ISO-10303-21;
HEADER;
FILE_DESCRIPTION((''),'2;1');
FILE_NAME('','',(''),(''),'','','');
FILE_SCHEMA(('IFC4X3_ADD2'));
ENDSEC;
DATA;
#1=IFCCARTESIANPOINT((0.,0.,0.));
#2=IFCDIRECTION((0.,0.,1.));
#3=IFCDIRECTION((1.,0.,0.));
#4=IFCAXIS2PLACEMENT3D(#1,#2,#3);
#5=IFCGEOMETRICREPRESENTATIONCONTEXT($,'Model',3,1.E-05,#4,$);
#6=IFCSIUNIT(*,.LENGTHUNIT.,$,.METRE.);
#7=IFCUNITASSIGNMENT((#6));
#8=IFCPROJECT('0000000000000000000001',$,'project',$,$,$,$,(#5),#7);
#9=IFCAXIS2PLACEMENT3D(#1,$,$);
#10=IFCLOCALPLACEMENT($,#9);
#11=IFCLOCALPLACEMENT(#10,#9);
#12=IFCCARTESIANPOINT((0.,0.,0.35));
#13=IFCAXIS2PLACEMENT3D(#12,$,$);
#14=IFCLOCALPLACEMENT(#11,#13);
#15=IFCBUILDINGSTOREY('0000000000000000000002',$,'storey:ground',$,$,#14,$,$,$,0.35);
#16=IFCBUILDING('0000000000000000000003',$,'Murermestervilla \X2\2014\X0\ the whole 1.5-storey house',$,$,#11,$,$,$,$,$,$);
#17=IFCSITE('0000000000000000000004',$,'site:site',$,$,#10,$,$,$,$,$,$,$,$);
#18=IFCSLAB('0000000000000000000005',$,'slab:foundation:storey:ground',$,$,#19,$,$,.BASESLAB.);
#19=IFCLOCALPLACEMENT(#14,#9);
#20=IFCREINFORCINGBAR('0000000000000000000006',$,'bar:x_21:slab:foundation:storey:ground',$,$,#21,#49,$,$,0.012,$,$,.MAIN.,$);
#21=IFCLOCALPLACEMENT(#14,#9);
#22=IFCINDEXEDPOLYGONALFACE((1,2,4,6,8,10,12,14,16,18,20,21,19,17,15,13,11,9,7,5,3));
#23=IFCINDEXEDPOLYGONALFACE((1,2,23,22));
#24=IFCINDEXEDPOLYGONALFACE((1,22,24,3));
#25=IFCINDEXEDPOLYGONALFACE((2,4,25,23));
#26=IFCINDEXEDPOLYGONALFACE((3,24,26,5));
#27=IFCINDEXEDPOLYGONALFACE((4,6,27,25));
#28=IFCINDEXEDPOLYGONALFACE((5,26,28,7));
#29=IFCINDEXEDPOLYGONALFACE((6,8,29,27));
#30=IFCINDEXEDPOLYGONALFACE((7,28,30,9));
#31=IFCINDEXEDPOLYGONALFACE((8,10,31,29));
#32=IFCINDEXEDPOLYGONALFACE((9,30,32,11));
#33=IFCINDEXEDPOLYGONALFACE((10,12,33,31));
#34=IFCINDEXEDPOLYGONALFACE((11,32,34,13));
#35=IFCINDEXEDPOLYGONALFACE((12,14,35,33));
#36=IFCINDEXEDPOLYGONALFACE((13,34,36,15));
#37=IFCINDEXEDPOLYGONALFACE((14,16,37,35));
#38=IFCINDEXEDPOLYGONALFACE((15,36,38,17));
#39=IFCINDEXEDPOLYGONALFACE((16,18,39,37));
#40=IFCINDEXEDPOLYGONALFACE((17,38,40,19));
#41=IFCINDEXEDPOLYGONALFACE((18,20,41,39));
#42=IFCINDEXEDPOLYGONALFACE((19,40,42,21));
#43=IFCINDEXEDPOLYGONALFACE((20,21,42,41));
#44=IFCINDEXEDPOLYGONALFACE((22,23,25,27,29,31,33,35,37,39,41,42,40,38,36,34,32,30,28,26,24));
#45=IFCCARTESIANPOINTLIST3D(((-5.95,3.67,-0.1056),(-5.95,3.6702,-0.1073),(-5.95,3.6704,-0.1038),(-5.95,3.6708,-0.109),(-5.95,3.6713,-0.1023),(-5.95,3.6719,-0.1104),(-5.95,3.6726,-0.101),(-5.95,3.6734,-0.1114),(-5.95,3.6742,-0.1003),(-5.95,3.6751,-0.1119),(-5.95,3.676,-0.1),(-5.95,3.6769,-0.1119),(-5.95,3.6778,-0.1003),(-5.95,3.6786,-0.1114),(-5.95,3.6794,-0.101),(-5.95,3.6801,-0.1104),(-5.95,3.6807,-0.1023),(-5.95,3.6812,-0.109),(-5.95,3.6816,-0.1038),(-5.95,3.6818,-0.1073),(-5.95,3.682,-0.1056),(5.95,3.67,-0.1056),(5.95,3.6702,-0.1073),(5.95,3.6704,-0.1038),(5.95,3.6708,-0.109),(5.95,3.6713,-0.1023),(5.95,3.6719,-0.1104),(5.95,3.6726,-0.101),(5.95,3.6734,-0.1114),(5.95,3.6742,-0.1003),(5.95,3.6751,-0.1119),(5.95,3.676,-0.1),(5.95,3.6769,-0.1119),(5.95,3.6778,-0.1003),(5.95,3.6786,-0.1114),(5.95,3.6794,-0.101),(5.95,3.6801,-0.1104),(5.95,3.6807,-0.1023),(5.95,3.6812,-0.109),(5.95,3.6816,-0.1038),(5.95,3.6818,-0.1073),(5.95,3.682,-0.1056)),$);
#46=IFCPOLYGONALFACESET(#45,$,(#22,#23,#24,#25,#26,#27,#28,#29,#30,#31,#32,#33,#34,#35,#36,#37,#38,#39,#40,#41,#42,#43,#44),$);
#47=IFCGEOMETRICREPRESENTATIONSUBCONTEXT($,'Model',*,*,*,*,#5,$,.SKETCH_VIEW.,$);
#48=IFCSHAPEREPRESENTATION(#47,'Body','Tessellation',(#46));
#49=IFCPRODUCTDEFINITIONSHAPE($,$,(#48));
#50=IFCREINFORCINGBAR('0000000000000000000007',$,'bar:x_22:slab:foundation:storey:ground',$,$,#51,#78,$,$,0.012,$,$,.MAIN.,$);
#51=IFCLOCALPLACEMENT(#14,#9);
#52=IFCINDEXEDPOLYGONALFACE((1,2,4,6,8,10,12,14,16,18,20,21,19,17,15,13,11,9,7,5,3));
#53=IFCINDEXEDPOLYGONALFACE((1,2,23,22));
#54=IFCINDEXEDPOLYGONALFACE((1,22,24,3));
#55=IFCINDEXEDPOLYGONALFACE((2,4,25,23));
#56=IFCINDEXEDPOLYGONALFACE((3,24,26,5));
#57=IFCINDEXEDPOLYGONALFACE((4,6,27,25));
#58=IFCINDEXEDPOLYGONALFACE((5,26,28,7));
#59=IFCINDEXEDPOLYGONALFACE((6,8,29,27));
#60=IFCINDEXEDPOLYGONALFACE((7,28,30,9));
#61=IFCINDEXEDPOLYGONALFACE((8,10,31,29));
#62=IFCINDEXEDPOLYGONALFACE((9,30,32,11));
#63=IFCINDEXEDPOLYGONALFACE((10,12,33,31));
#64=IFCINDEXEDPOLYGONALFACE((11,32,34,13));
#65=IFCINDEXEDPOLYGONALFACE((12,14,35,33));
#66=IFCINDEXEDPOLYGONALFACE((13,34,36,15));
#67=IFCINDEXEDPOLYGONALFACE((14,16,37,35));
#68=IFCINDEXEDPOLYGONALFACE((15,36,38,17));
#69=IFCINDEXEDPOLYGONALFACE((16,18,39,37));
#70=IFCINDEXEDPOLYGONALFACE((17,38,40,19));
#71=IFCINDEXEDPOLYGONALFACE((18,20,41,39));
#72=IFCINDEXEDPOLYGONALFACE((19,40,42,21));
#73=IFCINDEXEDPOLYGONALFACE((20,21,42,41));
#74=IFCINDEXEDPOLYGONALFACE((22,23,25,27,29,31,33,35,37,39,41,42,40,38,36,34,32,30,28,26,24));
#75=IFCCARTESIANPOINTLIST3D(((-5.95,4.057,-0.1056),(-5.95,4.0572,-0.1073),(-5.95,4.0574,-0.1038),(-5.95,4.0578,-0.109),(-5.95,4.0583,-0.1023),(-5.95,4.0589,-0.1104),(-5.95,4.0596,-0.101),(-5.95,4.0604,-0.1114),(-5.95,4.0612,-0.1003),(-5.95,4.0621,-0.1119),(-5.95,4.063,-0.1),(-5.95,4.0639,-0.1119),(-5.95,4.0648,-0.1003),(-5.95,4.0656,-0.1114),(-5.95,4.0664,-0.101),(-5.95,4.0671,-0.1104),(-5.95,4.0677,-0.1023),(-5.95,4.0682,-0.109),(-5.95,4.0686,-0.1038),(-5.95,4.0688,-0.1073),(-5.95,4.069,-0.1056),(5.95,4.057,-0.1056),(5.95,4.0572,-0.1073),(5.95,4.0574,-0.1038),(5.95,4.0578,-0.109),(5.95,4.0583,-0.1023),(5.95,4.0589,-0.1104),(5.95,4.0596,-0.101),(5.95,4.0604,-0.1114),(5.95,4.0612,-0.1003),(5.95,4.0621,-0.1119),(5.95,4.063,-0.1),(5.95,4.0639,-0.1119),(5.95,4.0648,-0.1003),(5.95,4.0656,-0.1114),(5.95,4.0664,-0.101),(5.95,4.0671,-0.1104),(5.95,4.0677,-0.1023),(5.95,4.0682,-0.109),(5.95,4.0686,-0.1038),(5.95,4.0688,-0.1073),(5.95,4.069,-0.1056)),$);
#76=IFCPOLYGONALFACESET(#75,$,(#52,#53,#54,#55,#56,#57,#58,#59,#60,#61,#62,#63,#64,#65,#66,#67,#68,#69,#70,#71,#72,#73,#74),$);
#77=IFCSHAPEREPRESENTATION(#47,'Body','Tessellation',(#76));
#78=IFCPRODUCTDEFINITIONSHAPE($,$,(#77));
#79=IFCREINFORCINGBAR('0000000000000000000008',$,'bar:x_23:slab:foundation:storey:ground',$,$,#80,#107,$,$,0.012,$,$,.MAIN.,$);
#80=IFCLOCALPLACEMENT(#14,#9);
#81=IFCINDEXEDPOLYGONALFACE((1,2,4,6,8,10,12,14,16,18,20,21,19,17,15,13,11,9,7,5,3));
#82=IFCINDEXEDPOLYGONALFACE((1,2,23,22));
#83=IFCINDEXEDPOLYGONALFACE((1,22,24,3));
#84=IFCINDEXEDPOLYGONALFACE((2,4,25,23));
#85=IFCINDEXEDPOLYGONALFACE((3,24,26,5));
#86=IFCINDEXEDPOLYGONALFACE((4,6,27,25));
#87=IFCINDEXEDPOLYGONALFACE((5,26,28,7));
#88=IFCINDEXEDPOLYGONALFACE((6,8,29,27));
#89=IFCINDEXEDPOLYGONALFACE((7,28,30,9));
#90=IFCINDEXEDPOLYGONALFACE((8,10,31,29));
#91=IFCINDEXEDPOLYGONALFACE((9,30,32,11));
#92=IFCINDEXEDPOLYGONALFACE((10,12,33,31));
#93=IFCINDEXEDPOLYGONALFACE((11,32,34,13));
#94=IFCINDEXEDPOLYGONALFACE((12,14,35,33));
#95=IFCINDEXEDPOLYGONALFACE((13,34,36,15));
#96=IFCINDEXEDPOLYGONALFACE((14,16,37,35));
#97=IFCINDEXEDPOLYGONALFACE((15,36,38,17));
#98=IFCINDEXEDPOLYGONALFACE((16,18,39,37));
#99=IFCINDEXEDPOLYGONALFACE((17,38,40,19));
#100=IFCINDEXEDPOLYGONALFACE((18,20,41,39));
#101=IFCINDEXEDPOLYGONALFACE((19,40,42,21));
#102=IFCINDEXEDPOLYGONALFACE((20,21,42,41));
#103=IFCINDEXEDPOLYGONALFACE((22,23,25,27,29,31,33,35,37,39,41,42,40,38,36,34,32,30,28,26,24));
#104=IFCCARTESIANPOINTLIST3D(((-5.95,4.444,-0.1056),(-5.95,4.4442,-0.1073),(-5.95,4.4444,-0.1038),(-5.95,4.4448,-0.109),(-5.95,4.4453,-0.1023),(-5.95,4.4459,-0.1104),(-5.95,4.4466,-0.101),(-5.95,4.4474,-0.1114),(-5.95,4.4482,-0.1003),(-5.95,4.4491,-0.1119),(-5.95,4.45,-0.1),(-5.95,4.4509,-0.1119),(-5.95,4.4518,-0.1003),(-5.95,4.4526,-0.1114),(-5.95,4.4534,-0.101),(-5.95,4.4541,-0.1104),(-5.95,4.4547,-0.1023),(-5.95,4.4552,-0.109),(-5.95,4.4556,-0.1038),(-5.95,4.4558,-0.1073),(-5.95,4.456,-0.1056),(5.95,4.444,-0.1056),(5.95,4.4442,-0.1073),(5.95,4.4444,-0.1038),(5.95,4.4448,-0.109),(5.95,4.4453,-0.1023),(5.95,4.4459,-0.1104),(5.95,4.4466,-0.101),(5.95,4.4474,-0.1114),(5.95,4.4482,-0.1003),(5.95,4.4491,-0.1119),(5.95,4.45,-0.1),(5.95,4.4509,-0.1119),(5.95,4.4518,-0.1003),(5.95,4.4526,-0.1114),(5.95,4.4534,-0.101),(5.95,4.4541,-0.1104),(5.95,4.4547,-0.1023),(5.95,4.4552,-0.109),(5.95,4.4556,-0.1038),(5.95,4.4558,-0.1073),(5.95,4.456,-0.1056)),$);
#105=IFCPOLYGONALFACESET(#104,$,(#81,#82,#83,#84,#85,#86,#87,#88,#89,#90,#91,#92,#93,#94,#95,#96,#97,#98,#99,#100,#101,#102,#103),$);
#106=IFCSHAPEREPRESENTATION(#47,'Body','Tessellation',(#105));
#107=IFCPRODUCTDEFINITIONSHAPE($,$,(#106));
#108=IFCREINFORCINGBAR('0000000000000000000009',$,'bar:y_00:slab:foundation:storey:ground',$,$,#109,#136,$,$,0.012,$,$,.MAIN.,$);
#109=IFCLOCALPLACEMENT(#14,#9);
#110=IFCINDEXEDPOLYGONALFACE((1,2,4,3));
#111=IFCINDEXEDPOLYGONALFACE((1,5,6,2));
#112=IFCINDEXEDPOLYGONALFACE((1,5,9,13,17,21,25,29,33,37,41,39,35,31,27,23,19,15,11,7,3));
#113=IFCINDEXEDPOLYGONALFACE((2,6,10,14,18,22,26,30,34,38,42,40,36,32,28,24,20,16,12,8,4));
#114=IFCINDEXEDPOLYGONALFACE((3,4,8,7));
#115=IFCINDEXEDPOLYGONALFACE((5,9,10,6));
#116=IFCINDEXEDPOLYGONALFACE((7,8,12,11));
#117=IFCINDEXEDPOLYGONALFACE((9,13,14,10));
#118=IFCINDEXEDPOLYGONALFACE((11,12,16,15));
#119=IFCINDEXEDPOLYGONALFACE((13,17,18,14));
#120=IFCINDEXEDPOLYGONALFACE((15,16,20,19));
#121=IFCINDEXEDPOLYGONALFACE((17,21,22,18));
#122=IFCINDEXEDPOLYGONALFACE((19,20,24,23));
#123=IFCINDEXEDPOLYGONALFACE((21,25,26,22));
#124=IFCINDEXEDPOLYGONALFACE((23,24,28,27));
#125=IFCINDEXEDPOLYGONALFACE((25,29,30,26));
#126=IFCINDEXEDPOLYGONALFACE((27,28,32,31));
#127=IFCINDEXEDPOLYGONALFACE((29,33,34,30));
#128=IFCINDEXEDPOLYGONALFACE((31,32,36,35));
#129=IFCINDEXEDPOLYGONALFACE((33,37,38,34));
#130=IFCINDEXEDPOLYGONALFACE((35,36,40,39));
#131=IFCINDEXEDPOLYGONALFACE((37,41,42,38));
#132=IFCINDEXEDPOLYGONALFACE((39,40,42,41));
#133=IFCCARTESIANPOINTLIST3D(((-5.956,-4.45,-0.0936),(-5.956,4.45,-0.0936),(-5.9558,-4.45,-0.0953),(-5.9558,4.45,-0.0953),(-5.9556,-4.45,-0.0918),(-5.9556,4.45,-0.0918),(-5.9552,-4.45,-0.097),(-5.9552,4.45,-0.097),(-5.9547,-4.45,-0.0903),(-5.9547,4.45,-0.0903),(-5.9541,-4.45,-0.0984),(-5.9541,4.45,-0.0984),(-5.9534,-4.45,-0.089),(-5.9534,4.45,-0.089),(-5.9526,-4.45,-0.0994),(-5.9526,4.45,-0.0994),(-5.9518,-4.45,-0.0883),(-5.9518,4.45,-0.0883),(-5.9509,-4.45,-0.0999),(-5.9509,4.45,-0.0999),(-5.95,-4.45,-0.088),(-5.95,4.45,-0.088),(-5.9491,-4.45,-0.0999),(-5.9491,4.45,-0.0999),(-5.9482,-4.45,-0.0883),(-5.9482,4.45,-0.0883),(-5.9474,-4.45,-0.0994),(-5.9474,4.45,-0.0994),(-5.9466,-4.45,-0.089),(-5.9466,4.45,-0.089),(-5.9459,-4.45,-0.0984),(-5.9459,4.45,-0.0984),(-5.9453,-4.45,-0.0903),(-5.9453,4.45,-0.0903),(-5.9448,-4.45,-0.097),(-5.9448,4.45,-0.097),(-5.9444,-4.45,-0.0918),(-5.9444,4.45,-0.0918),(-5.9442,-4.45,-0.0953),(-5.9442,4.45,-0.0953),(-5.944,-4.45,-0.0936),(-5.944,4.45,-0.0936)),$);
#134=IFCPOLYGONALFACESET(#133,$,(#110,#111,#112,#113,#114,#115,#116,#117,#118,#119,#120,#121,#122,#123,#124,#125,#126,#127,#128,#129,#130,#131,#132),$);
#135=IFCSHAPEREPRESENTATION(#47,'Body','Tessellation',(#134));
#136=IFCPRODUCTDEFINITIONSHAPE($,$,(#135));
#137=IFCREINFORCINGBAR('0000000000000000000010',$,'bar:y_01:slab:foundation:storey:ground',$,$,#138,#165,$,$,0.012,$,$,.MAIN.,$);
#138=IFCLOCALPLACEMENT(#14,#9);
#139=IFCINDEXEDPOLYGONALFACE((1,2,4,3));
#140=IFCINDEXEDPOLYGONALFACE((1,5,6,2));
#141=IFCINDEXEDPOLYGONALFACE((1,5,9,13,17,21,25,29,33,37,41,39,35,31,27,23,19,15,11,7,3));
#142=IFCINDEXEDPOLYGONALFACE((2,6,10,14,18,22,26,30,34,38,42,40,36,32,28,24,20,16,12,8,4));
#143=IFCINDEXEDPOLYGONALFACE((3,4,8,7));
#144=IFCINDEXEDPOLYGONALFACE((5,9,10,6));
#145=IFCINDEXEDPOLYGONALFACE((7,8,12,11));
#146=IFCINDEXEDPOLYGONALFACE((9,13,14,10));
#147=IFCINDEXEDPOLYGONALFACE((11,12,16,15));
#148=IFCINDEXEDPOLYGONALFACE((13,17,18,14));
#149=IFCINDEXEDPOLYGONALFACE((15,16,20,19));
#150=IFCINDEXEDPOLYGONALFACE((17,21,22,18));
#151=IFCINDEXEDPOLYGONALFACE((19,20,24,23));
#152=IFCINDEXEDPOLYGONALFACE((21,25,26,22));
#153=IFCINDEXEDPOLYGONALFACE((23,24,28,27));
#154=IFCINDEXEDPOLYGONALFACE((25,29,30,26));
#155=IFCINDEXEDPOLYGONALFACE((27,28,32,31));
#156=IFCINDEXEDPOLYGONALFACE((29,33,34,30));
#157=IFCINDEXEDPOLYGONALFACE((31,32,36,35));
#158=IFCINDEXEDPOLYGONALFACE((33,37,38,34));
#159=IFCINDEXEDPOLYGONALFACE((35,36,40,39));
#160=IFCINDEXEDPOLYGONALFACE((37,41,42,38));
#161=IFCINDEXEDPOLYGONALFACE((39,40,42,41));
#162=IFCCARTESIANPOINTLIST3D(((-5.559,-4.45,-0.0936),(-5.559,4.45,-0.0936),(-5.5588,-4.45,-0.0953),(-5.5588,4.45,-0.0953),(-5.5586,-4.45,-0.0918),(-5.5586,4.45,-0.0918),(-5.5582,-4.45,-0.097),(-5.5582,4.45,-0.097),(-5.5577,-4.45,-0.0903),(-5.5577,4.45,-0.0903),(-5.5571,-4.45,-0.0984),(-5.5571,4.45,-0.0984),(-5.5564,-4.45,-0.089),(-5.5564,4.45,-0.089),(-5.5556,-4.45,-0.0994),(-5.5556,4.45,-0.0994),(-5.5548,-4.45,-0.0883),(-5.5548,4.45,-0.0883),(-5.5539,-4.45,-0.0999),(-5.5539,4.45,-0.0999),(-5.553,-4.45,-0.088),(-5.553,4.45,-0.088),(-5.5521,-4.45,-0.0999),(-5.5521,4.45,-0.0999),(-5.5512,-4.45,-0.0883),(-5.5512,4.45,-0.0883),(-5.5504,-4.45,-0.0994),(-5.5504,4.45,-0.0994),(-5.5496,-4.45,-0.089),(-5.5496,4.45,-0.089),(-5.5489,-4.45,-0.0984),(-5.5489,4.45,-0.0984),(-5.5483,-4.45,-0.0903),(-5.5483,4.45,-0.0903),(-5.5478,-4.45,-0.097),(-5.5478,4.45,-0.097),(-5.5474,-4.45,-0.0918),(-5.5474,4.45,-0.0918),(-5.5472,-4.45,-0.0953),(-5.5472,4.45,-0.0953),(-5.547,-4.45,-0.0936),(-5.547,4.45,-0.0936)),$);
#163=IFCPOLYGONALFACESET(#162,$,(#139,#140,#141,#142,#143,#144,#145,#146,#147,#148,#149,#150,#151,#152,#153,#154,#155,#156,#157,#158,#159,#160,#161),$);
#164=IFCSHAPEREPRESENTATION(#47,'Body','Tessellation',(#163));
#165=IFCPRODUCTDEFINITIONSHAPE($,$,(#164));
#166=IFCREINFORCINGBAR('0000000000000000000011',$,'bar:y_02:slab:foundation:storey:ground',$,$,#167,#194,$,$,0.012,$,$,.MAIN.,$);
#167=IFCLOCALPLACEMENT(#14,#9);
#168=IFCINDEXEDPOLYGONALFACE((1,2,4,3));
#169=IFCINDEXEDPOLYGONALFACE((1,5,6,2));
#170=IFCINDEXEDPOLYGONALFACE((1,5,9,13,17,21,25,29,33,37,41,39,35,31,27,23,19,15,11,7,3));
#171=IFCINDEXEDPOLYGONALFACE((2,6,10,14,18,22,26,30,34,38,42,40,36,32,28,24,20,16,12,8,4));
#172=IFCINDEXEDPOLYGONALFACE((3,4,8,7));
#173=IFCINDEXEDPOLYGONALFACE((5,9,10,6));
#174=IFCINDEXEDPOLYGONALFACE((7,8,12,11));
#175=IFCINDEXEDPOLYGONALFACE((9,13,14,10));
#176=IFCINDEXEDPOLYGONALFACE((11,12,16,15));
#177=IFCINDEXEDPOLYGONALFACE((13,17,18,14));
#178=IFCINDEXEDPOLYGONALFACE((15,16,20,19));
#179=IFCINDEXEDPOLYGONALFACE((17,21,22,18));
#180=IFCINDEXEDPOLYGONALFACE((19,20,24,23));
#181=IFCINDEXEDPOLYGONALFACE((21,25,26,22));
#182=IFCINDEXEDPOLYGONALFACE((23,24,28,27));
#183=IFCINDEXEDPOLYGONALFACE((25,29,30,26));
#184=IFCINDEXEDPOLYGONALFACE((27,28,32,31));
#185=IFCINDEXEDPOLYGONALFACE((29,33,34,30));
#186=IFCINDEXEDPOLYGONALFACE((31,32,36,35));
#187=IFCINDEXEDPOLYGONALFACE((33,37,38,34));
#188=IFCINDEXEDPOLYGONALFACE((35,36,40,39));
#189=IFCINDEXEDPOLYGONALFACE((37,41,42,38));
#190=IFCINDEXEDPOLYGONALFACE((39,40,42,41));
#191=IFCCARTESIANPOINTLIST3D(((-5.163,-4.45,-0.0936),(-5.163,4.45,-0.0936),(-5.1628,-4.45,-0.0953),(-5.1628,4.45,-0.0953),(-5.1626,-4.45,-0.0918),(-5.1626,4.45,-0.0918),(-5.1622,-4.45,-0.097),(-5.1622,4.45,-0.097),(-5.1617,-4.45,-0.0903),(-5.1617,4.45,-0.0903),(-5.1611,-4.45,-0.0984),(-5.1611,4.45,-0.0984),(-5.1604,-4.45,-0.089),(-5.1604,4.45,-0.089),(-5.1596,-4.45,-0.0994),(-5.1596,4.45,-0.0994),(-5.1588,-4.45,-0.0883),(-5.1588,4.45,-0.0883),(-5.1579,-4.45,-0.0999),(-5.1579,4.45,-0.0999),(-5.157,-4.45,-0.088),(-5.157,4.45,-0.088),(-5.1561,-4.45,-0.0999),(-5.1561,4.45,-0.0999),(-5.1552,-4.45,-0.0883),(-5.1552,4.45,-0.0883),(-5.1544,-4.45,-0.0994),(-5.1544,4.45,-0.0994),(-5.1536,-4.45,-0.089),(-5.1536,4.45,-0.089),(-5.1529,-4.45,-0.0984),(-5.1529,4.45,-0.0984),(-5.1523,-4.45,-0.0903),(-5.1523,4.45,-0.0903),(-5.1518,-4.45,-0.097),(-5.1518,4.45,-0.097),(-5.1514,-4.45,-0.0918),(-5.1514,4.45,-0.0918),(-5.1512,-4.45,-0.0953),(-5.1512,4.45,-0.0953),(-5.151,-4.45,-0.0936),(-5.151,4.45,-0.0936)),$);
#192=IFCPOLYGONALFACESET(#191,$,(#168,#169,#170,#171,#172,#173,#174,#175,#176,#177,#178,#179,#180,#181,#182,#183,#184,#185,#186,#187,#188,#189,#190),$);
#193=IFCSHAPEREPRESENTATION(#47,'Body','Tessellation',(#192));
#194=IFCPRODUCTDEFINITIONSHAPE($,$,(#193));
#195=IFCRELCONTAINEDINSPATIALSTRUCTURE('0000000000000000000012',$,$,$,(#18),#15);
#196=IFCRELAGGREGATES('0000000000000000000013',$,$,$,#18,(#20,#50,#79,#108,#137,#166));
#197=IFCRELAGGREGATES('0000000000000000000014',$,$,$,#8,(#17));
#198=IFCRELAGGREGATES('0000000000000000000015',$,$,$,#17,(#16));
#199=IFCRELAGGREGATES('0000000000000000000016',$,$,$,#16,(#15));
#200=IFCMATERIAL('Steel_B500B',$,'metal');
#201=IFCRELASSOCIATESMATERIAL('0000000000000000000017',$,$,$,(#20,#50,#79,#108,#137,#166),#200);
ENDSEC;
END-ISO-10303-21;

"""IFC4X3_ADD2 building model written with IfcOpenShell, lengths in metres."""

from ifc_helpers import new_model, entity, si_unit, frame, origin, origin_with_axes, place, context, subcontext, project, spatial, material, element, aggregate, save


model = new_model("IFC4X3_ADD2")

# Units and contexts
model_context = context("Model", 3, precision=1e-05, world=origin_with_axes())
sub_context = subcontext(model_context, None, "Model", "SKETCH_VIEW")
ifc_project = project(units=[si_unit("LENGTHUNIT", "METRE")], contexts=[model_context])

# Site, building, storey
placement = place(None, origin())
site = spatial("IfcSite", under=ifc_project, at=placement, Name="site:site")
building_placement = place(placement, origin())
building = spatial("IfcBuilding", under=site, at=building_placement, Name="Murermestervilla — the whole 1.5-storey house")
storey_placement = place(building_placement, frame((0.0, 0.0, 0.35)))
storey = spatial("IfcBuildingStorey", under=building, at=storey_placement, Name="storey:ground", Elevation=0.35)

# Slab, reinforcing bars
slab_placement = place(storey_placement, frame((0.0, 0.0, -0.35)))
slab = element("IfcSlab", 1, at=slab_placement, inside=storey, Name="slab:foundation:storey:ground", PredefinedType="BASESLAB")
ifc_material = material(Name="Steel_B500B", Category="metal")
reinforcing_bar_1 = element("IfcReinforcingBar", 2, at=placement, material=ifc_material, Name="bar:x_21:slab:foundation:storey:ground", NominalDiameter=0.012, PredefinedType="MAIN", context=sub_context, shape_type="AdvancedSweptSolid", body=[
    entity("IfcSweptDiskSolid", entity("IfcPolyline", [entity("IfcCartesianPoint", [-5.95, 3.676, 0.244]), entity("IfcCartesianPoint", [5.95, 3.676, 0.244])]), 0.006),
])
reinforcing_bar_2 = element("IfcReinforcingBar", 3, at=placement, material=ifc_material, Name="bar:x_22:slab:foundation:storey:ground", NominalDiameter=0.012, PredefinedType="MAIN", context=sub_context, shape_type="AdvancedSweptSolid", body=[
    entity("IfcSweptDiskSolid", entity("IfcPolyline", [entity("IfcCartesianPoint", [-5.95, 4.063, 0.244]), entity("IfcCartesianPoint", [5.95, 4.063, 0.244])]), 0.006),
])
reinforcing_bar_3 = element("IfcReinforcingBar", 4, at=placement, material=ifc_material, Name="bar:x_23:slab:foundation:storey:ground", NominalDiameter=0.012, PredefinedType="MAIN", context=sub_context, shape_type="AdvancedSweptSolid", body=[
    entity("IfcSweptDiskSolid", entity("IfcPolyline", [entity("IfcCartesianPoint", [-5.95, 4.45, 0.244]), entity("IfcCartesianPoint", [5.95, 4.45, 0.244])]), 0.006),
])
reinforcing_bar_4 = element("IfcReinforcingBar", 5, at=placement, material=ifc_material, Name="bar:y_00:slab:foundation:storey:ground", NominalDiameter=0.012, PredefinedType="MAIN", context=sub_context, shape_type="AdvancedSweptSolid", body=[
    entity("IfcSweptDiskSolid", entity("IfcPolyline", [entity("IfcCartesianPoint", [-5.95, -4.45, 0.256]), entity("IfcCartesianPoint", [-5.95, 4.45, 0.256])]), 0.006),
])
reinforcing_bar_5 = element("IfcReinforcingBar", 6, at=placement, material=ifc_material, Name="bar:y_01:slab:foundation:storey:ground", NominalDiameter=0.012, PredefinedType="MAIN", context=sub_context, shape_type="AdvancedSweptSolid", body=[
    entity("IfcSweptDiskSolid", entity("IfcPolyline", [entity("IfcCartesianPoint", [-5.553, -4.45, 0.256]), entity("IfcCartesianPoint", [-5.553, 4.45, 0.256])]), 0.006),
])
reinforcing_bar_6 = element("IfcReinforcingBar", 7, at=placement, material=ifc_material, Name="bar:y_02:slab:foundation:storey:ground", NominalDiameter=0.012, PredefinedType="MAIN", context=sub_context, shape_type="AdvancedSweptSolid", body=[
    entity("IfcSweptDiskSolid", entity("IfcPolyline", [entity("IfcCartesianPoint", [-5.157, -4.45, 0.256]), entity("IfcCartesianPoint", [-5.157, 4.45, 0.256])]), 0.006),
])
aggregate(slab, [reinforcing_bar_1, reinforcing_bar_2, reinforcing_bar_3, reinforcing_bar_4, reinforcing_bar_5, reinforcing_bar_6])

save(model, "model.ifc")
